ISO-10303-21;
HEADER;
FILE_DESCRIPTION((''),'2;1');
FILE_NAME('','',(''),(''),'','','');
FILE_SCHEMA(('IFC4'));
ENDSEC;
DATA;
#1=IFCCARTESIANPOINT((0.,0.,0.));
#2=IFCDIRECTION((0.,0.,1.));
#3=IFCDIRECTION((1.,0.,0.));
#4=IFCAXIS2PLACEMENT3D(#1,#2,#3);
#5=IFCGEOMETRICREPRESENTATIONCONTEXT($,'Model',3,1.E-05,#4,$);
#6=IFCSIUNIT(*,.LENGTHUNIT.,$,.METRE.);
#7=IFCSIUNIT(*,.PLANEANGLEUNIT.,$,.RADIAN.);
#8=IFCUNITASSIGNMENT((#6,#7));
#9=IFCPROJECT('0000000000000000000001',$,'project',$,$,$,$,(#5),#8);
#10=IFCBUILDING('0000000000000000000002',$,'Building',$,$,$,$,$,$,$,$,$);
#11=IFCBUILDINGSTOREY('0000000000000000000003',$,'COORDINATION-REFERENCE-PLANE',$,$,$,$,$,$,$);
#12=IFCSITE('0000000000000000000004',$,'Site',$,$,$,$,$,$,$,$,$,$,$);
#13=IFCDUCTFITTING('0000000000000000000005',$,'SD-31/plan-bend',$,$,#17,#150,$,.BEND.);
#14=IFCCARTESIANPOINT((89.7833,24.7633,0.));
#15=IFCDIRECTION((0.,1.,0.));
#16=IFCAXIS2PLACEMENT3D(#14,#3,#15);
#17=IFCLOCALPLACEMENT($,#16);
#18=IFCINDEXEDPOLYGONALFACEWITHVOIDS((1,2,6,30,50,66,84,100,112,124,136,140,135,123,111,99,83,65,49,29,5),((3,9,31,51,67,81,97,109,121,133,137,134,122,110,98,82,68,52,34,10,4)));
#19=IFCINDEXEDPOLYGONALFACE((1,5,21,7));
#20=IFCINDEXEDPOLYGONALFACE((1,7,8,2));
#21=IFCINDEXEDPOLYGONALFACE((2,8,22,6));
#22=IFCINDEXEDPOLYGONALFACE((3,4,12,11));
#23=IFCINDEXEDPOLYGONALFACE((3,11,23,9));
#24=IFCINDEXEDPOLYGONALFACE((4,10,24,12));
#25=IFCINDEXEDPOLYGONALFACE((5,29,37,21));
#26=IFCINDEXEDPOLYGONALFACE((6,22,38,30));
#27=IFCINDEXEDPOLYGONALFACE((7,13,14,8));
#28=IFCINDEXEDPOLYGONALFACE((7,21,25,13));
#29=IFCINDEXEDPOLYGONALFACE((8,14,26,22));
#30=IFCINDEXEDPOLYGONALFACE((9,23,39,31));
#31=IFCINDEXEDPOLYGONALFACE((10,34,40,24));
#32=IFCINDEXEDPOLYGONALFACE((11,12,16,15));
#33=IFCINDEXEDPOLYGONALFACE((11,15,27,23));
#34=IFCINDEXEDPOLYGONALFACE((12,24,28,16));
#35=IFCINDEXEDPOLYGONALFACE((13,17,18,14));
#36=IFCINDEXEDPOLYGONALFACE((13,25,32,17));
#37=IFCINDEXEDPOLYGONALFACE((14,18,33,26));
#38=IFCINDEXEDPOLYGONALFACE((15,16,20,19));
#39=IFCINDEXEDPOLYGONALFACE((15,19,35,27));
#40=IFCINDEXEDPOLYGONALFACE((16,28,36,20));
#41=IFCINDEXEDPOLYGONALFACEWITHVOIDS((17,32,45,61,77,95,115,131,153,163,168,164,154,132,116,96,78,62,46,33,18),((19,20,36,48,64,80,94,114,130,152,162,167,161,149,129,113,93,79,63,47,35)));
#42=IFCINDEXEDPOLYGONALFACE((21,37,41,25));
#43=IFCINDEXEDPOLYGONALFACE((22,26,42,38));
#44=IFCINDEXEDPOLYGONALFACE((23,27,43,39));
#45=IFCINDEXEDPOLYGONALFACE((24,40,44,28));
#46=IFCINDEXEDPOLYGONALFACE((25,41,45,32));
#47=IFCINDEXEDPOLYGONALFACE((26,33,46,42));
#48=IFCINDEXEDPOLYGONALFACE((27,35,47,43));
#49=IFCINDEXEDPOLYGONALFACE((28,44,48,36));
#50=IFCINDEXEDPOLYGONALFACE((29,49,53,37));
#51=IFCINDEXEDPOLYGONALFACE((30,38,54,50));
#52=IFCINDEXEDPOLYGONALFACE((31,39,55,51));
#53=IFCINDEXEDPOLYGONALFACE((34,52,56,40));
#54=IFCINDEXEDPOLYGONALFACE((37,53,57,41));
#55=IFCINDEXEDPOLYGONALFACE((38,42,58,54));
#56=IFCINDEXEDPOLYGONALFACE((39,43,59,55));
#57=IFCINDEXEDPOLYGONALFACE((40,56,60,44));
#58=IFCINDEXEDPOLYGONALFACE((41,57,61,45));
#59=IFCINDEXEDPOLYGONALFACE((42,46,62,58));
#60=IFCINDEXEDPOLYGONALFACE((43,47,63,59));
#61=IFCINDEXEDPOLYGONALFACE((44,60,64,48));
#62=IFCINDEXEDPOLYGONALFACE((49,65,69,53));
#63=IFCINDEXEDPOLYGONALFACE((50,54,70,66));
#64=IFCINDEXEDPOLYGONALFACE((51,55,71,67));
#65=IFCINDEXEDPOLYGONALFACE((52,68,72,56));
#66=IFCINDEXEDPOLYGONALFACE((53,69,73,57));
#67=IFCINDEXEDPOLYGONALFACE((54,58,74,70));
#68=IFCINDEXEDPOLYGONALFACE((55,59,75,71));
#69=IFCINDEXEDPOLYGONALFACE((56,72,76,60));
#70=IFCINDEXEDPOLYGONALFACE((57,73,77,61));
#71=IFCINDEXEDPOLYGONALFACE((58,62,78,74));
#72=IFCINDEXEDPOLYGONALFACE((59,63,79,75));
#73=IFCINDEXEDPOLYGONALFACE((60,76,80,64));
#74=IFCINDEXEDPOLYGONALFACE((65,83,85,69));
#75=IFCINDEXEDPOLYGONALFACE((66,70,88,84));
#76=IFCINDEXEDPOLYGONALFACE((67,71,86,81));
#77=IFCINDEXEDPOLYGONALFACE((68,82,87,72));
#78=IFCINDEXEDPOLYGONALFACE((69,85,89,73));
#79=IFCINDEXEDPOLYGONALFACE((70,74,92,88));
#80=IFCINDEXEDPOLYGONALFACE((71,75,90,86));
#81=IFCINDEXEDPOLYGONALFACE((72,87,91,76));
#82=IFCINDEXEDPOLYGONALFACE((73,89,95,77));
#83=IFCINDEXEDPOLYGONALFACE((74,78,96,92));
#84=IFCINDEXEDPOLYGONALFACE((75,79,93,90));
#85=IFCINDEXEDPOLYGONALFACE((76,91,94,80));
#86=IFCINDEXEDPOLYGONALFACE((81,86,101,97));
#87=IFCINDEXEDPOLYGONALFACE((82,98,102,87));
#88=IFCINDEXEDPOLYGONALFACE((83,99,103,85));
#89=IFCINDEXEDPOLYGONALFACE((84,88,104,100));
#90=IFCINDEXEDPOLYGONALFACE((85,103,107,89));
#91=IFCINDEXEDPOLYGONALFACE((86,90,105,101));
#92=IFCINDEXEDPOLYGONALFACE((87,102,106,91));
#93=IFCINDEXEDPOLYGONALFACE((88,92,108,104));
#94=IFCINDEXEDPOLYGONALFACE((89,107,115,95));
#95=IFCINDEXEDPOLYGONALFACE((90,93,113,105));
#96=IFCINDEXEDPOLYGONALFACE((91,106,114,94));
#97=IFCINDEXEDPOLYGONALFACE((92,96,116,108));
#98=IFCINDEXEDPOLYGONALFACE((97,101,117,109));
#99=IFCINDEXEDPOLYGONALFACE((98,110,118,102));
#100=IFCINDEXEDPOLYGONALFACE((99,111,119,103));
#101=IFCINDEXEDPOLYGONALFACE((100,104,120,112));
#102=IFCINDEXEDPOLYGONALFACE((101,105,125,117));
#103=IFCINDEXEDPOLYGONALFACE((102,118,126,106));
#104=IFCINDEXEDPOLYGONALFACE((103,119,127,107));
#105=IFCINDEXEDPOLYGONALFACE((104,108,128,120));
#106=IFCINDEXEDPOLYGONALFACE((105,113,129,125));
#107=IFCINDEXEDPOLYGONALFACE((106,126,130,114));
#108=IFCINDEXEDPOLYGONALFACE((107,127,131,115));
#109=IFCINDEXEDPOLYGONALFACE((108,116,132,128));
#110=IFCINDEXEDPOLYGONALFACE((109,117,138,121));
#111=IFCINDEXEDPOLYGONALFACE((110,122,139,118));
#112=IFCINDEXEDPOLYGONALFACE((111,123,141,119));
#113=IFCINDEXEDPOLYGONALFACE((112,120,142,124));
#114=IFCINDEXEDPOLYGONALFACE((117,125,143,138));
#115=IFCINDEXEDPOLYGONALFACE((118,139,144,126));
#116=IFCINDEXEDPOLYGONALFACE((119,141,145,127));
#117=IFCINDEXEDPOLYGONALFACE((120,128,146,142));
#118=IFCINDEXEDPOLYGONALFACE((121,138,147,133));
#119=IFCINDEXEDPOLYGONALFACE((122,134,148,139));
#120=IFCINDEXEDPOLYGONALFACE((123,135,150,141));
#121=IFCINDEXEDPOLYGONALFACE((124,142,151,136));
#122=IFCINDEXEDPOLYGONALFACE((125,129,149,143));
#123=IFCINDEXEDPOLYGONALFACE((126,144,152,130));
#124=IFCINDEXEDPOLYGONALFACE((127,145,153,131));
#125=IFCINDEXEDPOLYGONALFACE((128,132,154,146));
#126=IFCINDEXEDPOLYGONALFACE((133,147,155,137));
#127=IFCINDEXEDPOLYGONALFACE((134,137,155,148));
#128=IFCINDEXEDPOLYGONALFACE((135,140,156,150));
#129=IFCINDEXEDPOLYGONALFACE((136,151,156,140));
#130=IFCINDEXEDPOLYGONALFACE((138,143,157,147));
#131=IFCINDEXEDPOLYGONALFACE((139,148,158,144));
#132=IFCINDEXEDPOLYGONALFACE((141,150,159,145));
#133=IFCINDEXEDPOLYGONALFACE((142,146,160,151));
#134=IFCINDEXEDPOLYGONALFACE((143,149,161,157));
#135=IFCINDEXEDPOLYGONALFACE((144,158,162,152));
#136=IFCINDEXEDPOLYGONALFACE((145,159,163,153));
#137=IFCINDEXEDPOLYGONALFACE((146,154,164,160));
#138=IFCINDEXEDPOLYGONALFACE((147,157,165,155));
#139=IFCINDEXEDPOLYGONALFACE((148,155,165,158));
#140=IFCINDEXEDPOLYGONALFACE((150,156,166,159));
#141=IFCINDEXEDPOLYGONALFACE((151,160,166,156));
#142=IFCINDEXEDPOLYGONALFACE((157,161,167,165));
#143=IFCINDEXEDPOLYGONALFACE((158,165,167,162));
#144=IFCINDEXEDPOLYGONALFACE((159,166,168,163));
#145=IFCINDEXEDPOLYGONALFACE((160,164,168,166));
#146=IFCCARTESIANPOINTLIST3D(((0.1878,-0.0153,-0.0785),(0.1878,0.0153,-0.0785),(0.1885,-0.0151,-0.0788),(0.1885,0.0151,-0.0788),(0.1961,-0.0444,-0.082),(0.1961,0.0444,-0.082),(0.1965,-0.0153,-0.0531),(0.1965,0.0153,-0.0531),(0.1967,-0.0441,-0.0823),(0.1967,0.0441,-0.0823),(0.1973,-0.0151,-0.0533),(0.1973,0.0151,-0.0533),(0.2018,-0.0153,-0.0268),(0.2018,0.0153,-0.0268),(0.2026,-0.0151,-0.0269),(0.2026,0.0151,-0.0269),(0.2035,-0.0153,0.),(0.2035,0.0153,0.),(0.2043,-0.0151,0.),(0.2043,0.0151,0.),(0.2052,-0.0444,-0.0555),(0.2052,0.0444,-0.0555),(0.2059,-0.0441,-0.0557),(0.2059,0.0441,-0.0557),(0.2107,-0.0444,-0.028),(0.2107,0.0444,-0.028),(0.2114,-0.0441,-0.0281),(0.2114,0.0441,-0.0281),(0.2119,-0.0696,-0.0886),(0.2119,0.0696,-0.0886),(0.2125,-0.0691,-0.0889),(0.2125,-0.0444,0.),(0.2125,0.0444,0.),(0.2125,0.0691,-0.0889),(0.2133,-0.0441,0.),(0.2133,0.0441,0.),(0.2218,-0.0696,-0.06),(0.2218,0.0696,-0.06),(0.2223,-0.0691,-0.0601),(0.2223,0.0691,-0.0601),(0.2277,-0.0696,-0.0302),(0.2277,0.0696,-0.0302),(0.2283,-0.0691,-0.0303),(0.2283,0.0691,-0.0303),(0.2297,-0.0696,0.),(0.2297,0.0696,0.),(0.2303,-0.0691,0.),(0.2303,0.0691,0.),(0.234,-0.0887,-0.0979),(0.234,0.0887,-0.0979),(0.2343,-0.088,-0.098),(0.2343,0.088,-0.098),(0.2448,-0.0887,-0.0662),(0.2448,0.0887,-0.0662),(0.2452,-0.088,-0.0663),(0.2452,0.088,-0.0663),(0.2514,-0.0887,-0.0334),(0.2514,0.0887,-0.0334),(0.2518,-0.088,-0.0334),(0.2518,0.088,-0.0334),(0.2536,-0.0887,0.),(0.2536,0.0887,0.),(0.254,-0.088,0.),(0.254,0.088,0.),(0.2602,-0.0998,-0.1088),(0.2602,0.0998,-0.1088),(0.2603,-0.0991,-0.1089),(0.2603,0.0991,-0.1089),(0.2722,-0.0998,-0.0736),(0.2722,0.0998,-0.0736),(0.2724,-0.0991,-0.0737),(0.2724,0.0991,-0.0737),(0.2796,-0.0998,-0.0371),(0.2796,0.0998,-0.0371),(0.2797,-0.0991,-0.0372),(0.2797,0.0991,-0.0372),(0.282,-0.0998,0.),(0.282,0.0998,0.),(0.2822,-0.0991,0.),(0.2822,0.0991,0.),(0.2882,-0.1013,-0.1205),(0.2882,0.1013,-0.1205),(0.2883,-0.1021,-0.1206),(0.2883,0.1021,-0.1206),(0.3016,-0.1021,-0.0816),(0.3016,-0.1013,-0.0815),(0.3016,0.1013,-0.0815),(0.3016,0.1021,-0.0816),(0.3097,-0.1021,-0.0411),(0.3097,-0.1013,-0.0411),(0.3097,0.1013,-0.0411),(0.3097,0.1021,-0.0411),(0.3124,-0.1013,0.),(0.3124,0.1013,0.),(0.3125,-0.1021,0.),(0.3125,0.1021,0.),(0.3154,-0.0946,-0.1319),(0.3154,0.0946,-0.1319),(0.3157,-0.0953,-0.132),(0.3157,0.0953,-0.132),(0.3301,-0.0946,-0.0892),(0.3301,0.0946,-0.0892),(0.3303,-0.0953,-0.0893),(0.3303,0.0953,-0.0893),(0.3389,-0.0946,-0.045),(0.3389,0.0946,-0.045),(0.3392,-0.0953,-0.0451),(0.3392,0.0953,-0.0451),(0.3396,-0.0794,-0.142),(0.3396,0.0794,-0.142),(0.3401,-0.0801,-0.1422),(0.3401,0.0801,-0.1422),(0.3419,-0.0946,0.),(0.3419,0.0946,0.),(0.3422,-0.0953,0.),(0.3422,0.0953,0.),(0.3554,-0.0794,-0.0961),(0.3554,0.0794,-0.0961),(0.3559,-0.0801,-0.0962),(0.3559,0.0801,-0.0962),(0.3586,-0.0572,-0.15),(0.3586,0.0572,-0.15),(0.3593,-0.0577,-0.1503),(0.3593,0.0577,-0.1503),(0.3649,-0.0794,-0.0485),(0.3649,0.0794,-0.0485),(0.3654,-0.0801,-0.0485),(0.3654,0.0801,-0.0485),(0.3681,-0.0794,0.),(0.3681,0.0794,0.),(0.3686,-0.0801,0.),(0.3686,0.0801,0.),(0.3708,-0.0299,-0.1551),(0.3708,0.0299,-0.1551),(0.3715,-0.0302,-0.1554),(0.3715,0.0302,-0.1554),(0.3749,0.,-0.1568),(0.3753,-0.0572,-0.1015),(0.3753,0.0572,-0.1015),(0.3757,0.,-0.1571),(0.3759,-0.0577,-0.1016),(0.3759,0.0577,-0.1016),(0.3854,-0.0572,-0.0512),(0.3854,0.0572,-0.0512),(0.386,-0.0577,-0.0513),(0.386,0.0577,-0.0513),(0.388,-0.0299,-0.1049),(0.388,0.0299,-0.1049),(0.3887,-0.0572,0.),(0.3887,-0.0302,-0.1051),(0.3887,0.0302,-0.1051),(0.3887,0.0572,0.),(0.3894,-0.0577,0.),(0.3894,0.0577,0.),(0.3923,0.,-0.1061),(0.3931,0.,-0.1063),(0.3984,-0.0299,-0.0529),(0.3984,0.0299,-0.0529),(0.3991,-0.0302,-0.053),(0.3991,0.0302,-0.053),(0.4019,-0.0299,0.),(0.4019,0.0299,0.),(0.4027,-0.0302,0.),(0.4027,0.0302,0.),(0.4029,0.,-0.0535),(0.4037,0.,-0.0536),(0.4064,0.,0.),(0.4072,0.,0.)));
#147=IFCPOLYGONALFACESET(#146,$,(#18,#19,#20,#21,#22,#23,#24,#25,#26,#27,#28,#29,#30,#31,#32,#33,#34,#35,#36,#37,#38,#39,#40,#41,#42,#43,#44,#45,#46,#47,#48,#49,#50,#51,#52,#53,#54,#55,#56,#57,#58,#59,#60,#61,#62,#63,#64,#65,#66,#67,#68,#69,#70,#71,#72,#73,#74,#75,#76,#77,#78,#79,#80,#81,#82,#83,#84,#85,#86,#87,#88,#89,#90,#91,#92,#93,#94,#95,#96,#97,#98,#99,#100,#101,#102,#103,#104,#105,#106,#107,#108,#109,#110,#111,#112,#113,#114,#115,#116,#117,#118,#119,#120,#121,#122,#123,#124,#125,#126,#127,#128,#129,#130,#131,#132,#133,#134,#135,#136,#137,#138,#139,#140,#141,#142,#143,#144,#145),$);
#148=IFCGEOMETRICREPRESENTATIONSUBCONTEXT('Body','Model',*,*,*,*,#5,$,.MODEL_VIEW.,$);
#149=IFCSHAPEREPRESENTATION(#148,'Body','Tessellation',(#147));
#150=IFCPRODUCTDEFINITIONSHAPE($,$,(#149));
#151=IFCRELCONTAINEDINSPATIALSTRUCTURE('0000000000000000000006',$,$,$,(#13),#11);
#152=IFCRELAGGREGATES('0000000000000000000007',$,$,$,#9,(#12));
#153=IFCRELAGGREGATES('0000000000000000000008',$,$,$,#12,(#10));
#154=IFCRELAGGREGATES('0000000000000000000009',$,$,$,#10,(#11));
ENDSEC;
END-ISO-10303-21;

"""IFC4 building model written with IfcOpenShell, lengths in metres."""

from ifc_helpers import new_model, entity, si_unit, frame, origin_with_axes, place, context, subcontext, project, spatial, element, save


model = new_model("IFC4")

# Units and contexts
model_context = context("Model", 3, precision=1e-05, world=origin_with_axes())
body_context_1 = subcontext(model_context, "Body", "Model", "MODEL_VIEW")
ifc_project = project(units=[si_unit("LENGTHUNIT", "METRE"), si_unit("PLANEANGLEUNIT", "RADIAN")], contexts=[model_context])

# Site, building, storey
site = spatial("IfcSite", under=ifc_project, Name="Site")
building = spatial("IfcBuilding", under=site, Name="Building")
storey = spatial("IfcBuildingStorey", under=building, Name="COORDINATION-REFERENCE-PLANE")

# Duct fitting
duct_fitting_1_placement = place(None, frame((89.7833, 24.7633, 0.0), z_axis=(1.0, 0.0, 0.0), x_axis=(0.0, 1.0, 0.0)))
element("IfcDuctFitting", 1, at=duct_fitting_1_placement, inside=storey, Name="SD-31/plan-bend", PredefinedType="BEND", context=body_context_1, shape_type="SweptSolid", body=[
    entity("IfcRevolvedAreaSolid", entity("IfcCircleHollowProfileDef", "AREA", None, entity("IfcAxis2Placement2D", entity("IfcCartesianPoint", [0.3048, 0.0])), 0.1024, 0.0008), entity("IfcAxis2Placement3D", entity("IfcCartesianPoint", [0.0, 0.0, 0.0]), entity("IfcDirection", [0.0, 0.0, 1.0]), entity("IfcDirection", [1.0, 0.0, 0.0])), entity("IfcAxis1Placement", entity("IfcCartesianPoint", [0.0, 0.0, 0.0]), entity("IfcDirection", [0.0, 1.0, 0.0])), 0.396124),
])

save(model, "model.ifc")
